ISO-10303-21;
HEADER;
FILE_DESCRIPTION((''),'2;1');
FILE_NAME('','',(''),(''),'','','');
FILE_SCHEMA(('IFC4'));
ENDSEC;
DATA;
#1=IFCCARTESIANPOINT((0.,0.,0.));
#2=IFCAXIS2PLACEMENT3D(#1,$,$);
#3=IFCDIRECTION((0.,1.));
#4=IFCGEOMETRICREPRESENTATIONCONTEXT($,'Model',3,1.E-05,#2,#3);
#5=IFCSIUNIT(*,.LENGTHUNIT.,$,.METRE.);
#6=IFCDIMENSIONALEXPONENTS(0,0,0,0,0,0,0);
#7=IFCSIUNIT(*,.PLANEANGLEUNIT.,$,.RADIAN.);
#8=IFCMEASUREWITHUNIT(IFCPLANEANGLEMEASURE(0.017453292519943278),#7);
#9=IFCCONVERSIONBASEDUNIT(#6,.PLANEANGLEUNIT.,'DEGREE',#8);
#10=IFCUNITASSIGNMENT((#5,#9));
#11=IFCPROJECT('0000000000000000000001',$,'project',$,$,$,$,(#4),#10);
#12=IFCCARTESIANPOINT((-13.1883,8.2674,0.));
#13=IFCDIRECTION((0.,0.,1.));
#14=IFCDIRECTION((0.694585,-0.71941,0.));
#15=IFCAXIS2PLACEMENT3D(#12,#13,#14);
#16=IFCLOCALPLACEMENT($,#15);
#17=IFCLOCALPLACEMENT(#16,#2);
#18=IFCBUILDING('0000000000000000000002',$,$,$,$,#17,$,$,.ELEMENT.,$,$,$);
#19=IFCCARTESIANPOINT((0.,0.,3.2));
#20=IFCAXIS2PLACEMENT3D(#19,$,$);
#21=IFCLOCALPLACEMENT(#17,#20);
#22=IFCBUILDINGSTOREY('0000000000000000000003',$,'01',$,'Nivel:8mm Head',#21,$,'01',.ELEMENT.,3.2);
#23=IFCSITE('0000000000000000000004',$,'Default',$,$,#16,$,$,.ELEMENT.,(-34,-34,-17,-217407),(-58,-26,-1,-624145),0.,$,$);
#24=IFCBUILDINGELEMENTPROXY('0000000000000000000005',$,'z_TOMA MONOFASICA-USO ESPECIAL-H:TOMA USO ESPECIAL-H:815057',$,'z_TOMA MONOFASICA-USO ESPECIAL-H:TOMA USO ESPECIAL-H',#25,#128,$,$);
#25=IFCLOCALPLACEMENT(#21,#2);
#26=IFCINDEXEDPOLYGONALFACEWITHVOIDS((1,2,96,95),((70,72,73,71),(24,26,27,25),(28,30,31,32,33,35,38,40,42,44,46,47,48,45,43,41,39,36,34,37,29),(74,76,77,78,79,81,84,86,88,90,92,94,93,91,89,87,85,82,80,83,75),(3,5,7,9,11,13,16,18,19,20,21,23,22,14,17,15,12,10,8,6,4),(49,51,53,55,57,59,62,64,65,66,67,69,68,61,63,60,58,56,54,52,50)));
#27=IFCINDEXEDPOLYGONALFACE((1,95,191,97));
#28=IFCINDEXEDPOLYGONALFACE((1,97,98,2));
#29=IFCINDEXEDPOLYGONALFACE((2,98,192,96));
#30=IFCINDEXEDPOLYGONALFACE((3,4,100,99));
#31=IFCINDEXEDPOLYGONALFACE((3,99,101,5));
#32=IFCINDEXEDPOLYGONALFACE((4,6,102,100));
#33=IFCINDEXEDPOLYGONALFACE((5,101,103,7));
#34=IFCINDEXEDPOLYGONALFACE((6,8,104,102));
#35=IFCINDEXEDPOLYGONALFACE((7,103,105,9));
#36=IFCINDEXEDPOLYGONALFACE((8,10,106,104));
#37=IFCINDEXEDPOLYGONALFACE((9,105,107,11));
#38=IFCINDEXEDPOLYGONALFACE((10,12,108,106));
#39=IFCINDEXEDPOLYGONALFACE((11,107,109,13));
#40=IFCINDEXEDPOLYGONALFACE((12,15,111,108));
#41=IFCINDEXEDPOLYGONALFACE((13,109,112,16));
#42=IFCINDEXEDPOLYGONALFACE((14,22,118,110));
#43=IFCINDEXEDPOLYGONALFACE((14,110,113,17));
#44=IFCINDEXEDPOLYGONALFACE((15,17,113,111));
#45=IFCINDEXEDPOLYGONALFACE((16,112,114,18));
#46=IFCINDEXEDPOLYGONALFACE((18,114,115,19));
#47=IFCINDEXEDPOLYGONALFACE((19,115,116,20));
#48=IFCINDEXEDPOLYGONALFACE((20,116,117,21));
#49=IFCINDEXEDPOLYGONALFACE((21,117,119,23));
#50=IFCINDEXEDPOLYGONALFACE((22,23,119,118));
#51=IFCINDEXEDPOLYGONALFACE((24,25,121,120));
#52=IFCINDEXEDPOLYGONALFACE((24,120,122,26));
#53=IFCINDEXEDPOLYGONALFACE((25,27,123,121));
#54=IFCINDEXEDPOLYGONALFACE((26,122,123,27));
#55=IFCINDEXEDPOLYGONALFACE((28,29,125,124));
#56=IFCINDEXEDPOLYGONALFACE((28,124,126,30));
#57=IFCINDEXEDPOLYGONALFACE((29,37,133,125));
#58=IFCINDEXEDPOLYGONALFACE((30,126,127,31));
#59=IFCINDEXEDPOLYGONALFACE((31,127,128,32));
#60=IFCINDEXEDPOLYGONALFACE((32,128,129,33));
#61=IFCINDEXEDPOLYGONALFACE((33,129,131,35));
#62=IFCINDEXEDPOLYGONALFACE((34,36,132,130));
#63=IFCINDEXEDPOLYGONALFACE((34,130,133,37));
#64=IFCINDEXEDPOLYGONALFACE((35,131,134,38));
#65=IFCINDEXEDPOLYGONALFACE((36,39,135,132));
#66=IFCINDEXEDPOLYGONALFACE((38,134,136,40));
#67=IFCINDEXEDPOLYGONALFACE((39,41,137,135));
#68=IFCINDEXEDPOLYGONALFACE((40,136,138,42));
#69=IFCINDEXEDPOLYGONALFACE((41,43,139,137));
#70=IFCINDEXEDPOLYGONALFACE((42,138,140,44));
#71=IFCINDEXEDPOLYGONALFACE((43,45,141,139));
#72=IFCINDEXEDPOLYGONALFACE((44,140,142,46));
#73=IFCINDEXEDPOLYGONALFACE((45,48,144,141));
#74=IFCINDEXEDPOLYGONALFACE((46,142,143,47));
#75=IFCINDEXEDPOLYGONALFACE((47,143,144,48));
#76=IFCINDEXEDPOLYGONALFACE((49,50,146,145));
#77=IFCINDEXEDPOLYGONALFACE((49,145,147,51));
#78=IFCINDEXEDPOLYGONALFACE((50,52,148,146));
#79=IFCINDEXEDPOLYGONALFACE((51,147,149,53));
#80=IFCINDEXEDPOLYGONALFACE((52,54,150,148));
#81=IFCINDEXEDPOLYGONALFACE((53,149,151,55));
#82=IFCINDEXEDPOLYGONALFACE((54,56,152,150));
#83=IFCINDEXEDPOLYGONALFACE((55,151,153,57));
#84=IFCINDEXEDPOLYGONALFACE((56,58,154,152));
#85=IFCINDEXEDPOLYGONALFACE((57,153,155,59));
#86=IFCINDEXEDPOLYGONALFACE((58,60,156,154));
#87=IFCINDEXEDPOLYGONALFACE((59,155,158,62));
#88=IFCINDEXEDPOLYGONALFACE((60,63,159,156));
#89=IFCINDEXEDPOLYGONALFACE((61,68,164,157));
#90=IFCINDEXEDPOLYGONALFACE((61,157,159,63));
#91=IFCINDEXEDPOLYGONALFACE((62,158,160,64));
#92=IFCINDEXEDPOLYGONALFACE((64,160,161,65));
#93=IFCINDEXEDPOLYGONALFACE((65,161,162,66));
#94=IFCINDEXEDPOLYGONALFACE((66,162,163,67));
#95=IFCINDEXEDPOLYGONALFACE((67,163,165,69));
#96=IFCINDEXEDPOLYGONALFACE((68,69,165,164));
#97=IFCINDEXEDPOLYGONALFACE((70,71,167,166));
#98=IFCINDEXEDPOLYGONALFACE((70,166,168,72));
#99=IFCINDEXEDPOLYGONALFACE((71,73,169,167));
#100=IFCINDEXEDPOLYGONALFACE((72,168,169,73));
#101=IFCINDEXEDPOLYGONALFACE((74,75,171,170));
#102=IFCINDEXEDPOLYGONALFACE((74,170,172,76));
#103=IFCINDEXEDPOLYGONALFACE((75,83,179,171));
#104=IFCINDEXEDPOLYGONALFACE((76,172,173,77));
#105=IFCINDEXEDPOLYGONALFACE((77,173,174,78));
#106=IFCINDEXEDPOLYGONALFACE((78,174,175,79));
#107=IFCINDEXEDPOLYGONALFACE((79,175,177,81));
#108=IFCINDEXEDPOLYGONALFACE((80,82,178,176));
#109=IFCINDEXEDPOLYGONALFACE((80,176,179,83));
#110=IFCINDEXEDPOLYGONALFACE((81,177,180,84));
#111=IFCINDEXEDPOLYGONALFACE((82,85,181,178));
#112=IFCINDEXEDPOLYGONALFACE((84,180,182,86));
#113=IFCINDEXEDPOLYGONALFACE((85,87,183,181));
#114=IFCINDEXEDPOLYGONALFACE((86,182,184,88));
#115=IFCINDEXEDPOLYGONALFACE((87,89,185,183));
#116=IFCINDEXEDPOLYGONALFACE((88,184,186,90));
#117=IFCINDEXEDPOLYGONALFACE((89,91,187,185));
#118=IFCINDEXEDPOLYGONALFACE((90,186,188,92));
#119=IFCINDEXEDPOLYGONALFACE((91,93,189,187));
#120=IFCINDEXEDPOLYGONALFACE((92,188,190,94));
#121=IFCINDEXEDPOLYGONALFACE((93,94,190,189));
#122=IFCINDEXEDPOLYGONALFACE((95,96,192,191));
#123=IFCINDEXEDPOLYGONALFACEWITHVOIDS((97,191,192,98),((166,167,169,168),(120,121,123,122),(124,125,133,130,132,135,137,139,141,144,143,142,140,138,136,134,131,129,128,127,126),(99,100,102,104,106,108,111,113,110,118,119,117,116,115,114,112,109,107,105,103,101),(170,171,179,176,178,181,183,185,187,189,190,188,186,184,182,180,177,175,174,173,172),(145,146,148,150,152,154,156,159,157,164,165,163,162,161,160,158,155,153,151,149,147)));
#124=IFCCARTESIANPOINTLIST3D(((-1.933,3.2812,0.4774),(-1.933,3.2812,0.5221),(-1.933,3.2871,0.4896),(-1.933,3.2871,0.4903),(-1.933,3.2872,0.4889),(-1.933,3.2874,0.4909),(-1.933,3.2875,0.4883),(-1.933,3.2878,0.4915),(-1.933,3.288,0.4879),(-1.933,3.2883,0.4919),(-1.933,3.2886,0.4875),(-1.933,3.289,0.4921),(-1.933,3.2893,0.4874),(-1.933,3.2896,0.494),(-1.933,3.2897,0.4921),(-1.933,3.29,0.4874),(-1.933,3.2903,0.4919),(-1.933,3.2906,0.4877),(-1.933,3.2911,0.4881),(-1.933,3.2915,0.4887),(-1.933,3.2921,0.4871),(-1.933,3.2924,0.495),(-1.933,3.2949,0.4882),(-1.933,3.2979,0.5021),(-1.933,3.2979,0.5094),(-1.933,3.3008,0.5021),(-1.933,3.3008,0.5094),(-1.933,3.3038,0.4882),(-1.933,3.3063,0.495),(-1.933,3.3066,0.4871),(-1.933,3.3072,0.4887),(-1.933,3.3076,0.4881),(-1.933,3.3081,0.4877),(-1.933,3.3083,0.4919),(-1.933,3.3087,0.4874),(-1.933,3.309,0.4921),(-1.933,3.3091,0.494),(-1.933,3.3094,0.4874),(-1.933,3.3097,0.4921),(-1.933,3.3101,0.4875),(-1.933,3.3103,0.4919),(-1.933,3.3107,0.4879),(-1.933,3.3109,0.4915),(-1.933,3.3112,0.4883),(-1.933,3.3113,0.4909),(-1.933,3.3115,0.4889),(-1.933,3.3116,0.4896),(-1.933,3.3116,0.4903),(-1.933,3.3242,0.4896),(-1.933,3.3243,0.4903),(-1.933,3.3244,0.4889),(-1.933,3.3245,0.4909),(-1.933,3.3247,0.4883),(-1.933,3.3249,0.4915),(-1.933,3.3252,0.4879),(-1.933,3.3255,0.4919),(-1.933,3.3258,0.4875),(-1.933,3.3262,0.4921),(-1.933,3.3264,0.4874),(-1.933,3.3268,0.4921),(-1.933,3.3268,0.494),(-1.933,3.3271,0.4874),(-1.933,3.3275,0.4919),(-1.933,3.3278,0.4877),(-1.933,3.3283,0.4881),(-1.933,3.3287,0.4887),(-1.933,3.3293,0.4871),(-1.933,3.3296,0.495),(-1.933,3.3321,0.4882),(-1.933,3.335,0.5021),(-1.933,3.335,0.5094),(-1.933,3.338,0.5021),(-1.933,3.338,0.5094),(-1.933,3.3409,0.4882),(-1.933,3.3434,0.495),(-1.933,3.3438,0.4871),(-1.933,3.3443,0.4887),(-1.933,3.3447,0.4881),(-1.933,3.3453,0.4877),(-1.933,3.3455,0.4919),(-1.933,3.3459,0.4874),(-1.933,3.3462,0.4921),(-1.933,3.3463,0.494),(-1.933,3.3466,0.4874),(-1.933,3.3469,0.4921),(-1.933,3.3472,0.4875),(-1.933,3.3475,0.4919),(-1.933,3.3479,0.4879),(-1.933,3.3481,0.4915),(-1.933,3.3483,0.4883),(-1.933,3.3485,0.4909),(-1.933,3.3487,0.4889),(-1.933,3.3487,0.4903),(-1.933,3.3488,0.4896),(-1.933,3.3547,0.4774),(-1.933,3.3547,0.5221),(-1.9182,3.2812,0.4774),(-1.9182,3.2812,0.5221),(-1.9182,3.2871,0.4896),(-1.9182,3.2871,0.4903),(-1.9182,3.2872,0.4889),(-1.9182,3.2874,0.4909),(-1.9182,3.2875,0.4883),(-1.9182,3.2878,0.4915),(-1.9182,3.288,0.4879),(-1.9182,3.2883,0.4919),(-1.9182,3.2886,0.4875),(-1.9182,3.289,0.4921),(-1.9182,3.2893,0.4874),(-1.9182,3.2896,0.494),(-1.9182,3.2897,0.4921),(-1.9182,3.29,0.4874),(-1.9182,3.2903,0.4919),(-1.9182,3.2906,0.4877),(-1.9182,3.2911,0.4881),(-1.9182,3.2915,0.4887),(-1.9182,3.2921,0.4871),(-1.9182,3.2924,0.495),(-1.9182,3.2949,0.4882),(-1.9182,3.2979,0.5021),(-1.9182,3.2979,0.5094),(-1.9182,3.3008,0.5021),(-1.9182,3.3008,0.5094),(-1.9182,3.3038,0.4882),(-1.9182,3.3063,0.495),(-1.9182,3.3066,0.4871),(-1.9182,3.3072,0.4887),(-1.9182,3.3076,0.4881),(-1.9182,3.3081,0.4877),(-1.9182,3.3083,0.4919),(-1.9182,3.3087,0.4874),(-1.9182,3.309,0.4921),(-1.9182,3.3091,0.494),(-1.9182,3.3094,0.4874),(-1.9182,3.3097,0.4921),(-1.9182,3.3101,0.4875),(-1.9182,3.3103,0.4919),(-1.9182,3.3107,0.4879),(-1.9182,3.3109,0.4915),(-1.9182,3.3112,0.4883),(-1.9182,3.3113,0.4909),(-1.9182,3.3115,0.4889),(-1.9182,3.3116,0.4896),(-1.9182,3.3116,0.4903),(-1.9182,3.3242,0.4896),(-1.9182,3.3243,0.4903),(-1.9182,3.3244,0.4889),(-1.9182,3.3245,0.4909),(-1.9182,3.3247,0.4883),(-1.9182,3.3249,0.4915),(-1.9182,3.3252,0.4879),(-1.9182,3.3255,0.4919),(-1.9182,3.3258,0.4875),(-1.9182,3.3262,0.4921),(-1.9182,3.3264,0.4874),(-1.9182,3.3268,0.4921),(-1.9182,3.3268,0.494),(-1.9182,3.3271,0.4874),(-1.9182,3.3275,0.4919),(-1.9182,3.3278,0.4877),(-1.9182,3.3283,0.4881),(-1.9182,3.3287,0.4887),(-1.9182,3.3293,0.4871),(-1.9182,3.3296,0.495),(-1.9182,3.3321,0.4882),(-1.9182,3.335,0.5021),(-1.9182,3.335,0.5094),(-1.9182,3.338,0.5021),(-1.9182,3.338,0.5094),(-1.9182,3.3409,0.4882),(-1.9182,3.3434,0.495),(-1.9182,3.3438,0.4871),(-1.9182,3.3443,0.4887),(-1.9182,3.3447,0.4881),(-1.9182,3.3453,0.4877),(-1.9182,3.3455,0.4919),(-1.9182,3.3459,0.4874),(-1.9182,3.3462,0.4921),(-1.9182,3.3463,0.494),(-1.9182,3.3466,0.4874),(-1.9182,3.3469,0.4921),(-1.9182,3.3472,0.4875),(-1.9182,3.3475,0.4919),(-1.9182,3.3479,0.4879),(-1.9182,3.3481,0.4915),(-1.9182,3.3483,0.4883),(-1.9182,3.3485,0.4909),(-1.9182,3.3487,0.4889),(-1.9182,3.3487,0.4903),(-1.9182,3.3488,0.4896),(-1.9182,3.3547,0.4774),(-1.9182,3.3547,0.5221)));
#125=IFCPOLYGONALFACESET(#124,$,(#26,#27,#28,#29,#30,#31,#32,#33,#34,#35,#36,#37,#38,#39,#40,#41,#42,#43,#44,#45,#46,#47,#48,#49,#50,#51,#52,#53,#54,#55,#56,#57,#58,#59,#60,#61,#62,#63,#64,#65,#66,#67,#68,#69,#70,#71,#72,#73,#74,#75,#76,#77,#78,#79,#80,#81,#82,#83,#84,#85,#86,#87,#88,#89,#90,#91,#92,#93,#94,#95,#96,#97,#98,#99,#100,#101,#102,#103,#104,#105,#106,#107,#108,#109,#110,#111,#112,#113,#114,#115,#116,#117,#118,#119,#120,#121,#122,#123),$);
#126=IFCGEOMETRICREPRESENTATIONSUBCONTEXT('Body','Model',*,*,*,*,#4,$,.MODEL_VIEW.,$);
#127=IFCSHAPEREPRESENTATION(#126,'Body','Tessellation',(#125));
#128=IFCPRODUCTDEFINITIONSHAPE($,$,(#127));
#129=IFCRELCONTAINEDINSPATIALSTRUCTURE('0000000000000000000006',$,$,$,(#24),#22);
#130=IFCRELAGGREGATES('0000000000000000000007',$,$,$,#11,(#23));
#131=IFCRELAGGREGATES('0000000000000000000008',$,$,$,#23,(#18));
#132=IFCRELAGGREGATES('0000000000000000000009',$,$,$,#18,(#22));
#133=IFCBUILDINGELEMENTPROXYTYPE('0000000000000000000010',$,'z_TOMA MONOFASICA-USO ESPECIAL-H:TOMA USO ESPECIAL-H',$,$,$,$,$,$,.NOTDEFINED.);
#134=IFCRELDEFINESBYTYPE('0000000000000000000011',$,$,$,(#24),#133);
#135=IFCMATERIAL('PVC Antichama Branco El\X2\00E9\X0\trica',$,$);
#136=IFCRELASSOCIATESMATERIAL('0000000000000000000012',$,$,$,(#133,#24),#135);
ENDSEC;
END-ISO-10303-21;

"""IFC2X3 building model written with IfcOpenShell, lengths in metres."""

from ifc_helpers import new_model, entity, si_unit, converted_unit, direction, frame, frame_2d, origin, place, context, subcontext, project, spatial, polyline, circle_curve, parameter, trimmed, segment, composite_curve, outline, extrude, source, transform, mapped, material, type_object, type_shapes, element, save


model = new_model("IFC2X3")

# Units and contexts
model_context = context("Model", 3, precision=1e-05, world=origin(), true_north=direction((0.0, 1.0)))
body_context = subcontext(model_context, "Body", "Model", "MODEL_VIEW")
ifc_project = project(units=[si_unit("LENGTHUNIT", "METRE"), converted_unit("PLANEANGLEUNIT", "DEGREE", entity("IfcPlaneAngleMeasure", 0.017453292519943278), si_unit("PLANEANGLEUNIT", "RADIAN"), dimensions=[0, 0, 0, 0, 0, 0, 0])], contexts=[model_context])

# Site, building, storey
site_placement = place(None, frame((-13.1883, 8.2674, 0.0), z_axis=(0.0, 0.0, 1.0), x_axis=(0.694585, -0.71941, 0.0)))
site = spatial("IfcSite", under=ifc_project, at=site_placement, Name="Default", CompositionType="ELEMENT", RefLatitude=(-34, -34, -17, -217407), RefLongitude=(-58, -26, -1, -624145), RefElevation=0.0)
building_placement = place(site_placement, origin())
building = spatial("IfcBuilding", under=site, at=building_placement, CompositionType="ELEMENT")
storey_placement = place(building_placement, frame((0.0, 0.0, 3.2)))
storey = spatial("IfcBuildingStorey", under=building, at=storey_placement, Name="01", ObjectType="Nivel:8mm Head", LongName="01", CompositionType="ELEMENT", Elevation=3.2)

# Building element proxy
ifc_material_1 = material(Name="PVC Antichama Branco Elétrica")
building_element_proxy_type_1 = type_object("IfcBuildingElementProxyType", Name="z_TOMA MONOFASICA-USO ESPECIAL-H:TOMA USO ESPECIAL-H", PredefinedType="NOTDEFINED", material=ifc_material_1)
shared_shape_1 = source(origin(), body_context, "Body", "SweptSolid", [
    extrude(outline(polyline([(-0.0368, -0.0223), (0.0368, -0.0223), (0.0368, 0.0223), (-0.0368, 0.0223), (-0.0368, -0.0223)]), holes=[composite_curve([segment(polyline([(0.0141, 0.0115), (0.0116, 0.0047)]), True, "CONTINUOUS"), segment(polyline([(0.0116, 0.0047), (0.0088, 0.0057)]), True, "CONTINUOUS"), segment(polyline([(0.0088, 0.0057), (0.0096, 0.0078)]), True, "CONTINUOUS"), segment(trimmed(circle_curve(frame_2d((0.0087, 0.0099), x_axis=(1.0, 0.0)), 0.0024), [parameter(27.118901)], [parameter(292.881099)], True, "PARAMETER"), False, "CONTINUOUS"), segment(polyline([(0.0108, 0.011), (0.0113, 0.0126)]), True, "CONTINUOUS"), segment(polyline([(0.0113, 0.0126), (0.0141, 0.0115)]), True, "CONTINUOUS")], self_intersect=False), composite_curve([segment(polyline([(0.0255, 0.0047), (0.023, 0.0115)]), True, "CONTINUOUS"), segment(polyline([(0.023, 0.0115), (0.0258, 0.0126)]), True, "CONTINUOUS"), segment(polyline([(0.0258, 0.0126), (0.0264, 0.011)]), True, "CONTINUOUS"), segment(trimmed(circle_curve(frame_2d((0.0285, 0.0099), x_axis=(1.0, 0.0)), 0.0024), [parameter(247.118901)], [parameter(152.881099)], True, "PARAMETER"), False, "CONTINUOUS"), segment(polyline([(0.0276, 0.0078), (0.0283, 0.0057)]), True, "CONTINUOUS"), segment(polyline([(0.0283, 0.0057), (0.0255, 0.0047)]), True, "CONTINUOUS")], self_intersect=False), polyline([(0.0201, -0.0024), (0.0201, -0.0097), (0.0171, -0.0097), (0.0171, -0.0024), (0.0201, -0.0024)]), composite_curve([segment(polyline([(-0.0141, 0.0115), (-0.0113, 0.0126)]), True, "CONTINUOUS"), segment(polyline([(-0.0113, 0.0126), (-0.0108, 0.011)]), True, "CONTINUOUS"), segment(trimmed(circle_curve(frame_2d((-0.0087, 0.0099), x_axis=(1.0, 0.0)), 0.0024), [parameter(247.118901)], [parameter(152.881099)], True, "PARAMETER"), False, "CONTINUOUS"), segment(polyline([(-0.0096, 0.0078), (-0.0088, 0.0057)]), True, "CONTINUOUS"), segment(polyline([(-0.0088, 0.0057), (-0.0116, 0.0047)]), True, "CONTINUOUS"), segment(polyline([(-0.0116, 0.0047), (-0.0141, 0.0115)]), True, "CONTINUOUS")], self_intersect=False), composite_curve([segment(polyline([(-0.0255, 0.0047), (-0.0283, 0.0057)]), True, "CONTINUOUS"), segment(polyline([(-0.0283, 0.0057), (-0.0276, 0.0078)]), True, "CONTINUOUS"), segment(trimmed(circle_curve(frame_2d((-0.0285, 0.0099), x_axis=(1.0, 0.0)), 0.0024), [parameter(27.118901)], [parameter(292.881099)], True, "PARAMETER"), False, "CONTINUOUS"), segment(polyline([(-0.0264, 0.011), (-0.0258, 0.0126)]), True, "CONTINUOUS"), segment(polyline([(-0.0258, 0.0126), (-0.023, 0.0115)]), True, "CONTINUOUS"), segment(polyline([(-0.023, 0.0115), (-0.0255, 0.0047)]), True, "CONTINUOUS")], self_intersect=False), polyline([(-0.0201, -0.0024), (-0.0171, -0.0024), (-0.0171, -0.0097), (-0.0201, -0.0097), (-0.0201, -0.0024)])]), frame((0.0, -0.005, 0.0223), z_axis=(0.0, 1.0, 0.0), x_axis=(1.0, 0.0, 0.0)), (0.0, 0.0, 1.0), 0.0148),
])
type_shapes(building_element_proxy_type_1, [shared_shape_1])
for number, where, z_axis, x_axis, name in (
    (1, (-1.928, 3.3179, 0.4774), (0.0, 0.0, 1.0), (0.0, -1.0, 0.0), "z_TOMA MONOFASICA-USO ESPECIAL-H:TOMA USO ESPECIAL-H:815057"),
):
    element("IfcBuildingElementProxy", number, at=place(storey_placement, frame(where, z_axis=z_axis, x_axis=x_axis)), inside=storey, type_object=building_element_proxy_type_1, material=ifc_material_1, Name=name, ObjectType="z_TOMA MONOFASICA-USO ESPECIAL-H:TOMA USO ESPECIAL-H", context=body_context, shape_type="MappedRepresentation", body=[
        mapped(shared_shape_1, transform((0.0, 0.0, 0.0), scale=1.0)),
    ])

save(model, "model.ifc")
